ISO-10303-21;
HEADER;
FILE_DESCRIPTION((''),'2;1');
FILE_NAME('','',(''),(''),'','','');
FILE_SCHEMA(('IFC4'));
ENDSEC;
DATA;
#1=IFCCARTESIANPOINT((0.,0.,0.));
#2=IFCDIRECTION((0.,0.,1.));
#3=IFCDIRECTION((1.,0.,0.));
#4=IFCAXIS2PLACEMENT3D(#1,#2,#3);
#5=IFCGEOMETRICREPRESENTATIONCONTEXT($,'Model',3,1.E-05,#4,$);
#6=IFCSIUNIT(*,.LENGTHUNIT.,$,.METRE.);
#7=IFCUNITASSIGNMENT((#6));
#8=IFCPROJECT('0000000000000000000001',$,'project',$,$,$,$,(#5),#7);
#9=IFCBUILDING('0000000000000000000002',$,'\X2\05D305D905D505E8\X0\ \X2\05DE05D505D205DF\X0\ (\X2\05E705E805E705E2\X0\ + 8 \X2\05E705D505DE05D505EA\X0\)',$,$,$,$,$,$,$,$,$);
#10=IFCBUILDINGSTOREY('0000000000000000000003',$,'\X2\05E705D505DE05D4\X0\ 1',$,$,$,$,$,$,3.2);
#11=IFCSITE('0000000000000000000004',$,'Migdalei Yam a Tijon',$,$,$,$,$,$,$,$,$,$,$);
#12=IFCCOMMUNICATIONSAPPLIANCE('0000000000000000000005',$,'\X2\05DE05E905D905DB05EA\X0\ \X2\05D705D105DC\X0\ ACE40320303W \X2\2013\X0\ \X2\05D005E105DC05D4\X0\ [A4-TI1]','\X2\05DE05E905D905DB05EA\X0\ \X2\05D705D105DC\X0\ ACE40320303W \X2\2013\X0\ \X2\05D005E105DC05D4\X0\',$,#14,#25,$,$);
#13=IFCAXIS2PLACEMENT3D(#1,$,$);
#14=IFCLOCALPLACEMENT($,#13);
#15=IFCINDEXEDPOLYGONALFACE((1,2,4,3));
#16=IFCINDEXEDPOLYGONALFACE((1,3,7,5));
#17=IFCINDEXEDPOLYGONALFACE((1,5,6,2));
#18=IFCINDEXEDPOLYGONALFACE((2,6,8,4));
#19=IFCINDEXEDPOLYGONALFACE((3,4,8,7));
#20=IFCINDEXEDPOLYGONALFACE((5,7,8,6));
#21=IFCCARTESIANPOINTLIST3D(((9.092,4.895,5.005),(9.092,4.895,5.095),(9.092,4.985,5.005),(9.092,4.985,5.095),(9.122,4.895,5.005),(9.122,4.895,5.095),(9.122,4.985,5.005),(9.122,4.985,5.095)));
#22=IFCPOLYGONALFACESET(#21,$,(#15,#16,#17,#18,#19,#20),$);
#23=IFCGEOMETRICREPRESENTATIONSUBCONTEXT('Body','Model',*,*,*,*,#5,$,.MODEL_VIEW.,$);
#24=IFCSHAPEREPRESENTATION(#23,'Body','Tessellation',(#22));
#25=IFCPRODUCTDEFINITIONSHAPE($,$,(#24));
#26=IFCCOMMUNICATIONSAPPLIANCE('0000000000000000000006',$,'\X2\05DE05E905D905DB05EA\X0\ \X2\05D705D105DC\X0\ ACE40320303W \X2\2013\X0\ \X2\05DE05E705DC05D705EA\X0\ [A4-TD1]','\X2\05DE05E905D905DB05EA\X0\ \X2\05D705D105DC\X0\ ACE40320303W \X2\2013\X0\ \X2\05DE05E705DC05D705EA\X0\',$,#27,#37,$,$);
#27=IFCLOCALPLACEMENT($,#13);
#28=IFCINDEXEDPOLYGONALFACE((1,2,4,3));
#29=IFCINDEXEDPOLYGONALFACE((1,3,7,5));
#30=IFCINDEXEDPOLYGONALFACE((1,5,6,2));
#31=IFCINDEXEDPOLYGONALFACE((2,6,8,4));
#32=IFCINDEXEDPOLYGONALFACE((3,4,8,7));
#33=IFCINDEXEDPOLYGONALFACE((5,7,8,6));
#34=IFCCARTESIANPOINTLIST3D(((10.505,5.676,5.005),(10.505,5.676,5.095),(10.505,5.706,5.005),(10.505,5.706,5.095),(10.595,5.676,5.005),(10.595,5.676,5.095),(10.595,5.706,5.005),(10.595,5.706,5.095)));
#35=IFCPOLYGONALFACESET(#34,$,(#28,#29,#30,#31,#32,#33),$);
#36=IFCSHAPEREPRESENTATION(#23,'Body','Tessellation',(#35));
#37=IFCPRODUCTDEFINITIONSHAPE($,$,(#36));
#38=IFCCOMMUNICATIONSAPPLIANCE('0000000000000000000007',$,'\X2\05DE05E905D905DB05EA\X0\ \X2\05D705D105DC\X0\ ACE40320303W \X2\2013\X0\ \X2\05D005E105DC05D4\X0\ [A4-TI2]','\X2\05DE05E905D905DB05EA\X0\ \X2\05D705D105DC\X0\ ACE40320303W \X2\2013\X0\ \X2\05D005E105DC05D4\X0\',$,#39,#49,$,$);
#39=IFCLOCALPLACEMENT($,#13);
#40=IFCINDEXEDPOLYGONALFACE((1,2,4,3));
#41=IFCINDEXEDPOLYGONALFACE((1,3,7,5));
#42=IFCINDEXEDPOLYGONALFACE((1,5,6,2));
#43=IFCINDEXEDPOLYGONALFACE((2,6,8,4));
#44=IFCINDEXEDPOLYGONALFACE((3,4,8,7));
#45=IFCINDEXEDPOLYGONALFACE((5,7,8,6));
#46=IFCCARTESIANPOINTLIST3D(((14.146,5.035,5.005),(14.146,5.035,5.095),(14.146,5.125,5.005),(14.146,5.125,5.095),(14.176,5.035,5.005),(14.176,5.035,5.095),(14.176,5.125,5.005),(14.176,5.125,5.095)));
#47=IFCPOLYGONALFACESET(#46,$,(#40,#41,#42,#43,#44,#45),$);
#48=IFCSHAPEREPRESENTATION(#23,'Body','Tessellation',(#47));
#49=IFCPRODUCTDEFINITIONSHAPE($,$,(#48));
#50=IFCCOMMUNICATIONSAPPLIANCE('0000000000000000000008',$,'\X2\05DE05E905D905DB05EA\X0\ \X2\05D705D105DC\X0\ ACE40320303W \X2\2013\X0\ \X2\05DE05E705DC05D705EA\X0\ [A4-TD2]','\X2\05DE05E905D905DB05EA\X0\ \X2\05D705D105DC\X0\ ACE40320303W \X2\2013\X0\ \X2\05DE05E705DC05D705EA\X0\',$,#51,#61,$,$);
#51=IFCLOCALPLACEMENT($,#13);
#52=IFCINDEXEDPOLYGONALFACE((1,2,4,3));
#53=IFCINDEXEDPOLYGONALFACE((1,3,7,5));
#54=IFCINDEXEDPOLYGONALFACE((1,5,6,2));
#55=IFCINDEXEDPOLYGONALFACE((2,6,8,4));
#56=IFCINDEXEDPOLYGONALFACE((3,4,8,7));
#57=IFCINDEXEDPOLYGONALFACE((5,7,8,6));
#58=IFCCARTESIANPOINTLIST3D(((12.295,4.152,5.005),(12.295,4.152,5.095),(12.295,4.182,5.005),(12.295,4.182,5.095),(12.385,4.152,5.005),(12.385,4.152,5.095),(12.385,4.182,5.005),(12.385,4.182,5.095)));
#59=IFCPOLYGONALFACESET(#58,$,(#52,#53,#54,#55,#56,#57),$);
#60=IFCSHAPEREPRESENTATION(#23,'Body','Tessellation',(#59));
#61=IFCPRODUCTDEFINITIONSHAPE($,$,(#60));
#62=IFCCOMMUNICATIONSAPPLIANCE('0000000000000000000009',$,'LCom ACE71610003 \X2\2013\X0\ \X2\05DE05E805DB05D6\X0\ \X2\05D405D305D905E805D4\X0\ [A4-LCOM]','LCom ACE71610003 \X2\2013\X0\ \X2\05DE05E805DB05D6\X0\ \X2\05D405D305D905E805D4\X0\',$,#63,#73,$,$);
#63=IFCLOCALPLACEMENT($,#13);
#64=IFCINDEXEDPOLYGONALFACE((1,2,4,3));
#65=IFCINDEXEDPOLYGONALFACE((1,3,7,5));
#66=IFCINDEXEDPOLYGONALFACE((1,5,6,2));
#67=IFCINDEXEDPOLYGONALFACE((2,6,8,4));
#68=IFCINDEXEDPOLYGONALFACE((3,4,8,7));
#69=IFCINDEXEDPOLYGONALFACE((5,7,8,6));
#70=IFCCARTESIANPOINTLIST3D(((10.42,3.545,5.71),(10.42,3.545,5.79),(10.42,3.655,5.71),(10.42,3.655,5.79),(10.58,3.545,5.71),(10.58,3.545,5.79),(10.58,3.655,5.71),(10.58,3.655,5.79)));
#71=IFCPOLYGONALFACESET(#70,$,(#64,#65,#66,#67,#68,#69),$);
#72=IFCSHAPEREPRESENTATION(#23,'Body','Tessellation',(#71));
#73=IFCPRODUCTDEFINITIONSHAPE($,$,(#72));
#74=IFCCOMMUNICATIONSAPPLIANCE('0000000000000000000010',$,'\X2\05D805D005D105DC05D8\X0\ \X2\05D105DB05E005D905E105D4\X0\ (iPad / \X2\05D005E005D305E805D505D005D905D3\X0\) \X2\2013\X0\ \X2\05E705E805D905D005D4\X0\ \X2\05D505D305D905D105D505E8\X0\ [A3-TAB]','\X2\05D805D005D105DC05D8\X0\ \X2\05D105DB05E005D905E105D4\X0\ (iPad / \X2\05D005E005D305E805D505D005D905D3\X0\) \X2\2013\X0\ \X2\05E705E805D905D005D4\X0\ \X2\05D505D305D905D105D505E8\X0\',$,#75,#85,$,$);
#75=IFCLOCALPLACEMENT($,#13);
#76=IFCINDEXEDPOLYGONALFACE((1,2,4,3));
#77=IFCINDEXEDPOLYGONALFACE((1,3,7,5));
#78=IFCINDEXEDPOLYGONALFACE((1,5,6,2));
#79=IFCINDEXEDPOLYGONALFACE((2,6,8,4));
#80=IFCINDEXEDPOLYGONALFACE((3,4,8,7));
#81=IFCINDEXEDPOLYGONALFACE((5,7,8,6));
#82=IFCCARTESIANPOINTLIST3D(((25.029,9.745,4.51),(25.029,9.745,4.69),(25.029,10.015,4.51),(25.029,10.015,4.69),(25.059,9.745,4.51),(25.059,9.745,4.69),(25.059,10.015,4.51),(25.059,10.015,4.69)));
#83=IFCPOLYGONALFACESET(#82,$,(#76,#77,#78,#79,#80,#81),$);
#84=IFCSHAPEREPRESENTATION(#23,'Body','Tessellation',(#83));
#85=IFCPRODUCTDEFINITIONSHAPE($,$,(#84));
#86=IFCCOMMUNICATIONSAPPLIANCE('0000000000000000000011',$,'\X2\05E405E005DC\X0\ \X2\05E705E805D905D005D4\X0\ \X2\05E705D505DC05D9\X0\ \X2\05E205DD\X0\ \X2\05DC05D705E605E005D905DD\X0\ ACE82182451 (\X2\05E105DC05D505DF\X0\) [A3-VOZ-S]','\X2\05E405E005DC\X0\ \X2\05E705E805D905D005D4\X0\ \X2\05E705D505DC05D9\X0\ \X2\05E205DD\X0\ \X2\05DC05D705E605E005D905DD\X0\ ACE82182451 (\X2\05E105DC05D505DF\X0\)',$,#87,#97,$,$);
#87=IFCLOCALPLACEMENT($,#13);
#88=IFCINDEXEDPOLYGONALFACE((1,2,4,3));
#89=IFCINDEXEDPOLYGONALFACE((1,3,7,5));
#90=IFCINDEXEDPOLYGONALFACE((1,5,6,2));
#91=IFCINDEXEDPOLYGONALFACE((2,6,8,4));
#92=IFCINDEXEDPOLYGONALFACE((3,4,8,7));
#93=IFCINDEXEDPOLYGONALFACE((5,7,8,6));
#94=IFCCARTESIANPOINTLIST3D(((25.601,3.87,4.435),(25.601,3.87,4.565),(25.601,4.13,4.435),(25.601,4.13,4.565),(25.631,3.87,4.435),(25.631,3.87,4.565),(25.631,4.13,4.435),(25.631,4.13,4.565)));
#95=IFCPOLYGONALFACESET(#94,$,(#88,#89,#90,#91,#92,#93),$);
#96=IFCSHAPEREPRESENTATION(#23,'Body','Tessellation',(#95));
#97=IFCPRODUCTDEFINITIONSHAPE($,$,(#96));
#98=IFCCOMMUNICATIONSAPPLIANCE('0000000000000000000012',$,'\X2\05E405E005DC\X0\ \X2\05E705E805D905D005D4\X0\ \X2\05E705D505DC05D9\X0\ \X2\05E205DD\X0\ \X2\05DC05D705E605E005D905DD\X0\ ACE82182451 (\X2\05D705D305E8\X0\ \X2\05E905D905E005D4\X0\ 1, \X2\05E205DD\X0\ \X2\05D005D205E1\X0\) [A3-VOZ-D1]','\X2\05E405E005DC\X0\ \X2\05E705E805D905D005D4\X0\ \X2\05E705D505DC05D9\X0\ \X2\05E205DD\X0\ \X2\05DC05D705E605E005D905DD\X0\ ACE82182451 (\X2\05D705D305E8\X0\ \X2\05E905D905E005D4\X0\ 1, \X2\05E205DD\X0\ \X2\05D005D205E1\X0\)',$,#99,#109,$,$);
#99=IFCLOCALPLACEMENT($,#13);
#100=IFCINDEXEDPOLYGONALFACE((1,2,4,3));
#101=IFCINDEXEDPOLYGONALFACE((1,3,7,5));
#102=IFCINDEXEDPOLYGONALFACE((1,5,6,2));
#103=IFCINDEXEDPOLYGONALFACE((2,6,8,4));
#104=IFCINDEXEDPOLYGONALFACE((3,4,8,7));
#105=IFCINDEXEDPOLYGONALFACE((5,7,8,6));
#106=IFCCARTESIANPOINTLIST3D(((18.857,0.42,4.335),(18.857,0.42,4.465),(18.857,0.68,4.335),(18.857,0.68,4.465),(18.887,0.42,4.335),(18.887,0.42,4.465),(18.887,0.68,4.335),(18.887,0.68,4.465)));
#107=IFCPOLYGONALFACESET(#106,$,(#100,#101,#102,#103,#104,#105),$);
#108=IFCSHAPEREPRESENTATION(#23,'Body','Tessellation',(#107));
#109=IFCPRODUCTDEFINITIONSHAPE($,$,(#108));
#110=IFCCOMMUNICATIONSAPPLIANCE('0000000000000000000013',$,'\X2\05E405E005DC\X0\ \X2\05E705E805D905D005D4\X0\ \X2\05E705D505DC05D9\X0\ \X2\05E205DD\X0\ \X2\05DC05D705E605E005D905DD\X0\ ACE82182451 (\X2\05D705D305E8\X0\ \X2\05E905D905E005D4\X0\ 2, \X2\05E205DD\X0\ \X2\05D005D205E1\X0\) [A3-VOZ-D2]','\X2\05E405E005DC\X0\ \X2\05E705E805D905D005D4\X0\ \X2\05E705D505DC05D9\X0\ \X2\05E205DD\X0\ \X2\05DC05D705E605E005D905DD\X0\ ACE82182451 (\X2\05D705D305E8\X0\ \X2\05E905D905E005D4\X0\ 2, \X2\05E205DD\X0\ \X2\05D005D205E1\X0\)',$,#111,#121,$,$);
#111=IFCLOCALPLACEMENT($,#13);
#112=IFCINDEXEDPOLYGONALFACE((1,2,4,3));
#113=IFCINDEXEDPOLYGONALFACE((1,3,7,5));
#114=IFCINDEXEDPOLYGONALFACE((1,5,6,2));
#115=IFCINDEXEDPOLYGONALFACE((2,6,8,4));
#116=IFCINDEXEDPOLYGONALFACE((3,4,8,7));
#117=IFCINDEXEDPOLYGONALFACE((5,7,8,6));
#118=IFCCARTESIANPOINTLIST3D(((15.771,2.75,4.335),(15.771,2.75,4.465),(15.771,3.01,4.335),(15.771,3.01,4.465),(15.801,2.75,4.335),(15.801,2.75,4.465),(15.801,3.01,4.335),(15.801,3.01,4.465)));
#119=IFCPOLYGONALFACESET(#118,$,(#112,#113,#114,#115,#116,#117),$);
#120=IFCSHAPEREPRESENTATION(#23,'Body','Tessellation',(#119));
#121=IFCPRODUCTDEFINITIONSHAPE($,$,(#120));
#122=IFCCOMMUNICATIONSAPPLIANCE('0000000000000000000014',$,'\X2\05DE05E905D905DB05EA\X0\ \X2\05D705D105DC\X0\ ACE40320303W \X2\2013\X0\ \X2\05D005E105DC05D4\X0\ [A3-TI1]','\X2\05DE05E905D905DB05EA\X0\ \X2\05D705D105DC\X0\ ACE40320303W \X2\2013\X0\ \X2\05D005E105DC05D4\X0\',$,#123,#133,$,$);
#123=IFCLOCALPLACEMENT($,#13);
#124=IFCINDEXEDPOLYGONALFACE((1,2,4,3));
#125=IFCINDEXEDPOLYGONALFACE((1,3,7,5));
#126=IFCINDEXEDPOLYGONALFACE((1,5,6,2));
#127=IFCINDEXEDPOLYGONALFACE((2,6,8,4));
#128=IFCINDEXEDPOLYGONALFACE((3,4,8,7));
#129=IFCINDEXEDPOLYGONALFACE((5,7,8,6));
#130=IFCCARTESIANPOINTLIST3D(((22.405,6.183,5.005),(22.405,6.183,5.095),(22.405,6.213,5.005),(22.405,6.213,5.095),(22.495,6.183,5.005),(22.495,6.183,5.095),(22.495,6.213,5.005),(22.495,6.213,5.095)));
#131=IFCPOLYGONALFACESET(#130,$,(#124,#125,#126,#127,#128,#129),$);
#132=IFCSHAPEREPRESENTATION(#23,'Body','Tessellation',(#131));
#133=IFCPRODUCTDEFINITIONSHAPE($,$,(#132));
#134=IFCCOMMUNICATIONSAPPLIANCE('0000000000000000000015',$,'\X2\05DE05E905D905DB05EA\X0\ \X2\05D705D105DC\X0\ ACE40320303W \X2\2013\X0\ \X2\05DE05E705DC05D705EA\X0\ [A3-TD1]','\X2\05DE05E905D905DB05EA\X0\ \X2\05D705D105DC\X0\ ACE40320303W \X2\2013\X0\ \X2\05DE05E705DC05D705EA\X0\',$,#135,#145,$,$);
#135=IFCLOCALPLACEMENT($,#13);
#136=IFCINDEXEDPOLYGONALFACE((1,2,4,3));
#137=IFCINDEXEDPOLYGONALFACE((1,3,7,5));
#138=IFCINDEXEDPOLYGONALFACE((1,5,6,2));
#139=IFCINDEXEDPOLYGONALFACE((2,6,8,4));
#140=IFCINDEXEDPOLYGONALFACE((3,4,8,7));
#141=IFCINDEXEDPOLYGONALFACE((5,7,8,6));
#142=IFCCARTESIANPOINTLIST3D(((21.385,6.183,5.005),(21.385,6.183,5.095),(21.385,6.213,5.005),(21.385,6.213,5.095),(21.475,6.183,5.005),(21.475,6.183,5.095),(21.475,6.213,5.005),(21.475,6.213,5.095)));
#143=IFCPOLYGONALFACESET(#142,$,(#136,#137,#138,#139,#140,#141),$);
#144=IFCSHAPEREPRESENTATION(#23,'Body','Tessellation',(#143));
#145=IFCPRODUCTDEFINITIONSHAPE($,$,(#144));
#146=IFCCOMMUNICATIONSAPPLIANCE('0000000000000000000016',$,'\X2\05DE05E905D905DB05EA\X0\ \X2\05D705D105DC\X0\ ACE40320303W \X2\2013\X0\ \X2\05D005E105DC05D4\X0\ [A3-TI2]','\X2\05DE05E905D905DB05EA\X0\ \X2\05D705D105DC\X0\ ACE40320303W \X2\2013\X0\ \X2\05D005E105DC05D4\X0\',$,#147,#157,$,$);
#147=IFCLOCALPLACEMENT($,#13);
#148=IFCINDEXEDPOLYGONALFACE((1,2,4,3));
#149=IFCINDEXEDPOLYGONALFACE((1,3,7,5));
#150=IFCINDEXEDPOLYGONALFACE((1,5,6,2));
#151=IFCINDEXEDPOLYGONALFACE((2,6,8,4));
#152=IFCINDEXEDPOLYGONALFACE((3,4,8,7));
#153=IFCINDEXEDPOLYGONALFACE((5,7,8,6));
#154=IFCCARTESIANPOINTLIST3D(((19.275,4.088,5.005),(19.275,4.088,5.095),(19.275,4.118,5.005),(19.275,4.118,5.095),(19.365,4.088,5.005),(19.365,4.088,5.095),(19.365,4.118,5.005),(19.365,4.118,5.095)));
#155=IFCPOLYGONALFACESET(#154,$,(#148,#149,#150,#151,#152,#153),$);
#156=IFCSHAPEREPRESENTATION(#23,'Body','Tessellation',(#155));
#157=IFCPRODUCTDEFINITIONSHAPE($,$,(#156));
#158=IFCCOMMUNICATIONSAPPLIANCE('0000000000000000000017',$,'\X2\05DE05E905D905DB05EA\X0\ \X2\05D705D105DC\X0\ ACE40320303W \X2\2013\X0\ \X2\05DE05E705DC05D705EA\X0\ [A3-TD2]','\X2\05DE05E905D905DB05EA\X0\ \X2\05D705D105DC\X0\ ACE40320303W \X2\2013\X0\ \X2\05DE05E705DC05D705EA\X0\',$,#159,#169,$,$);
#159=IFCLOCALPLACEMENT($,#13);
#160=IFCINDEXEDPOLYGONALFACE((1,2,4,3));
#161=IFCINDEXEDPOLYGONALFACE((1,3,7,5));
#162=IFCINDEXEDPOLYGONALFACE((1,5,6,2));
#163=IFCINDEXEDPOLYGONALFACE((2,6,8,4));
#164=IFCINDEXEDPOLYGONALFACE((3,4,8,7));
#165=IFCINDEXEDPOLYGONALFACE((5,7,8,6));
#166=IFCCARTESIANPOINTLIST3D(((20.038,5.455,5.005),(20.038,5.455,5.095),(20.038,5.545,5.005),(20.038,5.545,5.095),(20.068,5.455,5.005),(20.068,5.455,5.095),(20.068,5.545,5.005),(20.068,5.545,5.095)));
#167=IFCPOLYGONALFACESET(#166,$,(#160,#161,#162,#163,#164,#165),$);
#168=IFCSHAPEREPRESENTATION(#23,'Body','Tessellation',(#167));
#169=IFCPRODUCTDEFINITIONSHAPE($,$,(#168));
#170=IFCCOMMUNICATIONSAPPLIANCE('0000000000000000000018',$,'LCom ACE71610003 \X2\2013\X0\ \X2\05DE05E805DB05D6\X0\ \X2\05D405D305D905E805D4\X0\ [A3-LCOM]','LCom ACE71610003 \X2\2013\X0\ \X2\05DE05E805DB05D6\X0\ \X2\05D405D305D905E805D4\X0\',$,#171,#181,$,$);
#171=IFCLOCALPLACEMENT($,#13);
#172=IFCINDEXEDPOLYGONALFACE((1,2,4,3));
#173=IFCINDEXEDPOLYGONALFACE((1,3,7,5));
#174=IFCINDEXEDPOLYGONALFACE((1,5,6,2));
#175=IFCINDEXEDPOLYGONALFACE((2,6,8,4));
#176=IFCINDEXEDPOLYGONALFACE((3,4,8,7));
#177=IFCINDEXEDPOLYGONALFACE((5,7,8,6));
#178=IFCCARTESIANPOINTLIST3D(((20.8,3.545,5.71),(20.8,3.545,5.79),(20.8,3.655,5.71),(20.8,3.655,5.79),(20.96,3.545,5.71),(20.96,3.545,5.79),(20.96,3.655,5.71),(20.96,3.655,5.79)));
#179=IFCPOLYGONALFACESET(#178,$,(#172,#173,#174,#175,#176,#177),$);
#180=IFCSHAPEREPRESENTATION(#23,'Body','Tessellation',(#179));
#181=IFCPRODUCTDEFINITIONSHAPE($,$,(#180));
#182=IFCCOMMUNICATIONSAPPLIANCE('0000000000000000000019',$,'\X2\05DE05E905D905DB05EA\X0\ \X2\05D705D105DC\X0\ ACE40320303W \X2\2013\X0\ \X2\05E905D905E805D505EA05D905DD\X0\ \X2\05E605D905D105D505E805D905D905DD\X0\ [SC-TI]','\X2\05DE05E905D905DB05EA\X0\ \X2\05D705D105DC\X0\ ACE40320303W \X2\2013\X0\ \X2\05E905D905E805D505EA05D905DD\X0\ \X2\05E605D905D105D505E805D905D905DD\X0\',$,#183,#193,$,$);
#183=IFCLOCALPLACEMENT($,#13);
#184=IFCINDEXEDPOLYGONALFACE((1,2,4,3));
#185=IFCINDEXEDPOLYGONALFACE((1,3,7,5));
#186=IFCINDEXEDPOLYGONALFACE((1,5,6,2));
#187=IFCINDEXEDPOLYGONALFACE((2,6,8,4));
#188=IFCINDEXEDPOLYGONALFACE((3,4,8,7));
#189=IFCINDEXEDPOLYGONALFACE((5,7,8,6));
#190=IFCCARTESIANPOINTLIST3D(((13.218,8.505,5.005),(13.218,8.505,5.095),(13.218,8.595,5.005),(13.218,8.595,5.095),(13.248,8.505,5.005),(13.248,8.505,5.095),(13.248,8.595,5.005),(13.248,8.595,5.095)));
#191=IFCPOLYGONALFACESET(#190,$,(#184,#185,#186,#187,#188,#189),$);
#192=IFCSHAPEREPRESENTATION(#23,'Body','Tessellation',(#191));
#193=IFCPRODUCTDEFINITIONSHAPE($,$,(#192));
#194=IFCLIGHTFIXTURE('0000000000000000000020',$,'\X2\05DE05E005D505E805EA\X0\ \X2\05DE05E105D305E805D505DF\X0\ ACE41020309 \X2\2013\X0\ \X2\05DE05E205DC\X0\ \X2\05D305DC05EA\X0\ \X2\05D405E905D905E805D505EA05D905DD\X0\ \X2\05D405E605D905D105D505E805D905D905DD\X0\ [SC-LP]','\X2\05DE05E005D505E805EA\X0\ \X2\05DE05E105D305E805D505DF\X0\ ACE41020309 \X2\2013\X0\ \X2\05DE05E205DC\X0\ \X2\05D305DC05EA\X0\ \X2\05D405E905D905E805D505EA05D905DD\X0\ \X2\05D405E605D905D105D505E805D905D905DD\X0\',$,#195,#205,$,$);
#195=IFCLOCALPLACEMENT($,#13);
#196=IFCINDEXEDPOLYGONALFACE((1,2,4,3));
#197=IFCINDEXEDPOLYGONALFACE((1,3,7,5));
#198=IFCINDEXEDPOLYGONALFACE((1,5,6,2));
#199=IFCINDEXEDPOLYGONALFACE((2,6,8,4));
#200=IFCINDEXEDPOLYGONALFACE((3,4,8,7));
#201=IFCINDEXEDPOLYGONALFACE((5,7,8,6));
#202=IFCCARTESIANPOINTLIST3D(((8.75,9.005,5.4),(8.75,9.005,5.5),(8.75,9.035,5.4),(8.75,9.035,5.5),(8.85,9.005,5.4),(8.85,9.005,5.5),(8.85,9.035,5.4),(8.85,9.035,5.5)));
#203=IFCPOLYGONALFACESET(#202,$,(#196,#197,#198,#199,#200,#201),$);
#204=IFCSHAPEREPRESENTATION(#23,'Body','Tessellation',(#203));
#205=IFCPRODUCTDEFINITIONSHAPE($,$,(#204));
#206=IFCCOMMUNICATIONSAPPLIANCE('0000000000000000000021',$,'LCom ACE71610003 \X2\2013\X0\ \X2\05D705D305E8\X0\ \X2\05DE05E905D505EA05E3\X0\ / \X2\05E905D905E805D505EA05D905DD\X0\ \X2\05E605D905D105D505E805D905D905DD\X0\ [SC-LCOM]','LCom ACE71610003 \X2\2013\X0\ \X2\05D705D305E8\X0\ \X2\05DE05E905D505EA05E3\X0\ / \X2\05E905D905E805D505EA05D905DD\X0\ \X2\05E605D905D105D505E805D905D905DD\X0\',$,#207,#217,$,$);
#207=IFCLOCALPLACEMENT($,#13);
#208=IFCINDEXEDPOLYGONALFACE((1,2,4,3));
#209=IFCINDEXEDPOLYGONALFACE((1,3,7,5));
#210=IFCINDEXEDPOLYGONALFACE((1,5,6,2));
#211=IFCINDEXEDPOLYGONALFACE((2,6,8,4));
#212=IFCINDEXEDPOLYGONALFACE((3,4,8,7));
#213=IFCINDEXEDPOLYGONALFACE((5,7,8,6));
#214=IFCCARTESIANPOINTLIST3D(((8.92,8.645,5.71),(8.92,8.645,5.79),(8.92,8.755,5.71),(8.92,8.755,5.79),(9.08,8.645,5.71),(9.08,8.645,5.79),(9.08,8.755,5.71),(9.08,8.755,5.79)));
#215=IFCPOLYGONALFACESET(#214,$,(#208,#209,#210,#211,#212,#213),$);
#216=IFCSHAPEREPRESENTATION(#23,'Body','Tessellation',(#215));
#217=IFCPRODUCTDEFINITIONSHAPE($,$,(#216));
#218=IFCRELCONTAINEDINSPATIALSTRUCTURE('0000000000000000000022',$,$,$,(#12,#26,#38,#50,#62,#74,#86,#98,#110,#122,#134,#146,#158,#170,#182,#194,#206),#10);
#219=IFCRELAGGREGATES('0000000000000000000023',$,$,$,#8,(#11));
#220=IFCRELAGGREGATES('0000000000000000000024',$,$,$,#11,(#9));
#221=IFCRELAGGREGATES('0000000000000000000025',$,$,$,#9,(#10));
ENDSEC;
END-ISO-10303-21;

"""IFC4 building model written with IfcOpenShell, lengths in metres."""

from ifc_helpers import new_model, si_unit, frame, origin_with_axes, context, subcontext, project, spatial, line, indexed_curve, outline, extrude, element, save


model = new_model("IFC4")

# Units and contexts
model_context = context("Model", 3, precision=1e-05, world=origin_with_axes())
body_context = subcontext(model_context, "Body", "Model", "MODEL_VIEW")
ifc_project = project(units=[si_unit("LENGTHUNIT", "METRE")], contexts=[model_context])

# Site, building, storey
site = spatial("IfcSite", under=ifc_project, Name="Migdalei Yam a Tijon")
building = spatial("IfcBuilding", under=site, Name="דיור מוגן (קרקע + 8 קומות)")
storey = spatial("IfcBuildingStorey", under=building, Name="קומה 1", Elevation=3.2)

# Communications appliances
element("IfcCommunicationsAppliance", 1, inside=storey, Name="משיכת חבל ACE40320303W – אסלה [A4-TI1]", Description="משיכת חבל ACE40320303W – אסלה", context=body_context, shape_type="SweptSolid", body=[
    extrude(outline(indexed_curve([(0.0, 0.0), (0.03, 0.0), (0.03, 0.09), (0.0, 0.09)], segments=[line(1, 2, 3, 4, 1)])), frame((9.092, 4.895, 5.005), z_axis=(0.0, 0.0, 1.0), x_axis=(1.0, 0.0, 0.0)), (0.0, 0.0, 1.0), 0.09),
])
element("IfcCommunicationsAppliance", 2, inside=storey, Name="משיכת חבל ACE40320303W – מקלחת [A4-TD1]", Description="משיכת חבל ACE40320303W – מקלחת", context=body_context, shape_type="SweptSolid", body=[
    extrude(outline(indexed_curve([(0.0, 0.0), (0.09, 0.0), (0.09, 0.03), (0.0, 0.03)], segments=[line(1, 2, 3, 4, 1)])), frame((10.505, 5.676, 5.005), z_axis=(0.0, 0.0, 1.0), x_axis=(1.0, 0.0, 0.0)), (0.0, 0.0, 1.0), 0.09),
])
element("IfcCommunicationsAppliance", 3, inside=storey, Name="משיכת חבל ACE40320303W – אסלה [A4-TI2]", Description="משיכת חבל ACE40320303W – אסלה", context=body_context, shape_type="SweptSolid", body=[
    extrude(outline(indexed_curve([(0.0, 0.0), (0.03, 0.0), (0.03, 0.09), (0.0, 0.09)], segments=[line(1, 2, 3, 4, 1)])), frame((14.146, 5.035, 5.005), z_axis=(0.0, 0.0, 1.0), x_axis=(1.0, 0.0, 0.0)), (0.0, 0.0, 1.0), 0.09),
])
element("IfcCommunicationsAppliance", 4, inside=storey, Name="משיכת חבל ACE40320303W – מקלחת [A4-TD2]", Description="משיכת חבל ACE40320303W – מקלחת", context=body_context, shape_type="SweptSolid", body=[
    extrude(outline(indexed_curve([(0.0, 0.0), (0.09, 0.0), (0.09, 0.03), (0.0, 0.03)], segments=[line(1, 2, 3, 4, 1)])), frame((12.295, 4.152, 5.005), z_axis=(0.0, 0.0, 1.0), x_axis=(1.0, 0.0, 0.0)), (0.0, 0.0, 1.0), 0.09),
])
element("IfcCommunicationsAppliance", 5, inside=storey, Name="LCom ACE71610003 – מרכז הדירה [A4-LCOM]", Description="LCom ACE71610003 – מרכז הדירה", context=body_context, shape_type="SweptSolid", body=[
    extrude(outline(indexed_curve([(0.0, 0.0), (0.16, 0.0), (0.16, 0.11), (0.0, 0.11)], segments=[line(1, 2, 3, 4, 1)])), frame((10.42, 3.545, 5.71), z_axis=(0.0, 0.0, 1.0), x_axis=(1.0, 0.0, 0.0)), (0.0, 0.0, 1.0), 0.08),
])
element("IfcCommunicationsAppliance", 6, inside=storey, Name="טאבלט בכניסה (iPad / אנדרואיד) – קריאה ודיבור [A3-TAB]", Description="טאבלט בכניסה (iPad / אנדרואיד) – קריאה ודיבור", context=body_context, shape_type="SweptSolid", body=[
    extrude(outline(indexed_curve([(0.0, 0.0), (0.03, 0.0), (0.03, 0.27), (0.0, 0.27)], segments=[line(1, 2, 3, 4, 1)])), frame((25.029, 9.745, 4.51), z_axis=(0.0, 0.0, 1.0), x_axis=(1.0, 0.0, 0.0)), (0.0, 0.0, 1.0), 0.18),
])
element("IfcCommunicationsAppliance", 7, inside=storey, Name="פנל קריאה קולי עם לחצנים ACE82182451 (סלון) [A3-VOZ-S]", Description="פנל קריאה קולי עם לחצנים ACE82182451 (סלון)", context=body_context, shape_type="SweptSolid", body=[
    extrude(outline(indexed_curve([(0.0, 0.0), (0.03, 0.0), (0.03, 0.26), (0.0, 0.26)], segments=[line(1, 2, 3, 4, 1)])), frame((25.601, 3.87, 4.435), z_axis=(0.0, 0.0, 1.0), x_axis=(1.0, 0.0, 0.0)), (0.0, 0.0, 1.0), 0.13),
])
element("IfcCommunicationsAppliance", 8, inside=storey, Name="פנל קריאה קולי עם לחצנים ACE82182451 (חדר שינה 1, עם אגס) [A3-VOZ-D1]", Description="פנל קריאה קולי עם לחצנים ACE82182451 (חדר שינה 1, עם אגס)", context=body_context, shape_type="SweptSolid", body=[
    extrude(outline(indexed_curve([(0.0, 0.0), (0.03, 0.0), (0.03, 0.26), (0.0, 0.26)], segments=[line(1, 2, 3, 4, 1)])), frame((18.857, 0.42, 4.335), z_axis=(0.0, 0.0, 1.0), x_axis=(1.0, 0.0, 0.0)), (0.0, 0.0, 1.0), 0.13),
])
element("IfcCommunicationsAppliance", 9, inside=storey, Name="פנל קריאה קולי עם לחצנים ACE82182451 (חדר שינה 2, עם אגס) [A3-VOZ-D2]", Description="פנל קריאה קולי עם לחצנים ACE82182451 (חדר שינה 2, עם אגס)", context=body_context, shape_type="SweptSolid", body=[
    extrude(outline(indexed_curve([(0.0, 0.0), (0.03, 0.0), (0.03, 0.26), (0.0, 0.26)], segments=[line(1, 2, 3, 4, 1)])), frame((15.771, 2.75, 4.335), z_axis=(0.0, 0.0, 1.0), x_axis=(1.0, 0.0, 0.0)), (0.0, 0.0, 1.0), 0.13),
])
element("IfcCommunicationsAppliance", 10, inside=storey, Name="משיכת חבל ACE40320303W – אסלה [A3-TI1]", Description="משיכת חבל ACE40320303W – אסלה", context=body_context, shape_type="SweptSolid", body=[
    extrude(outline(indexed_curve([(0.0, 0.0), (0.09, 0.0), (0.09, 0.03), (0.0, 0.03)], segments=[line(1, 2, 3, 4, 1)])), frame((22.405, 6.183, 5.005), z_axis=(0.0, 0.0, 1.0), x_axis=(1.0, 0.0, 0.0)), (0.0, 0.0, 1.0), 0.09),
])
element("IfcCommunicationsAppliance", 11, inside=storey, Name="משיכת חבל ACE40320303W – מקלחת [A3-TD1]", Description="משיכת חבל ACE40320303W – מקלחת", context=body_context, shape_type="SweptSolid", body=[
    extrude(outline(indexed_curve([(0.0, 0.0), (0.09, 0.0), (0.09, 0.03), (0.0, 0.03)], segments=[line(1, 2, 3, 4, 1)])), frame((21.385, 6.183, 5.005), z_axis=(0.0, 0.0, 1.0), x_axis=(1.0, 0.0, 0.0)), (0.0, 0.0, 1.0), 0.09),
])
element("IfcCommunicationsAppliance", 12, inside=storey, Name="משיכת חבל ACE40320303W – אסלה [A3-TI2]", Description="משיכת חבל ACE40320303W – אסלה", context=body_context, shape_type="SweptSolid", body=[
    extrude(outline(indexed_curve([(0.0, 0.0), (0.09, 0.0), (0.09, 0.03), (0.0, 0.03)], segments=[line(1, 2, 3, 4, 1)])), frame((19.275, 4.088, 5.005), z_axis=(0.0, 0.0, 1.0), x_axis=(1.0, 0.0, 0.0)), (0.0, 0.0, 1.0), 0.09),
])
element("IfcCommunicationsAppliance", 13, inside=storey, Name="משיכת חבל ACE40320303W – מקלחת [A3-TD2]", Description="משיכת חבל ACE40320303W – מקלחת", context=body_context, shape_type="SweptSolid", body=[
    extrude(outline(indexed_curve([(0.0, 0.0), (0.03, 0.0), (0.03, 0.09), (0.0, 0.09)], segments=[line(1, 2, 3, 4, 1)])), frame((20.038, 5.455, 5.005), z_axis=(0.0, 0.0, 1.0), x_axis=(1.0, 0.0, 0.0)), (0.0, 0.0, 1.0), 0.09),
])
element("IfcCommunicationsAppliance", 14, inside=storey, Name="LCom ACE71610003 – מרכז הדירה [A3-LCOM]", Description="LCom ACE71610003 – מרכז הדירה", context=body_context, shape_type="SweptSolid", body=[
    extrude(outline(indexed_curve([(0.0, 0.0), (0.16, 0.0), (0.16, 0.11), (0.0, 0.11)], segments=[line(1, 2, 3, 4, 1)])), frame((20.8, 3.545, 5.71), z_axis=(0.0, 0.0, 1.0), x_axis=(1.0, 0.0, 0.0)), (0.0, 0.0, 1.0), 0.08),
])
element("IfcCommunicationsAppliance", 15, inside=storey, Name="משיכת חבל ACE40320303W – שירותים ציבוריים [SC-TI]", Description="משיכת חבל ACE40320303W – שירותים ציבוריים", context=body_context, shape_type="SweptSolid", body=[
    extrude(outline(indexed_curve([(0.0, 0.0), (0.03, 0.0), (0.03, 0.09), (0.0, 0.09)], segments=[line(1, 2, 3, 4, 1)])), frame((13.218, 8.505, 5.005), z_axis=(0.0, 0.0, 1.0), x_axis=(1.0, 0.0, 0.0)), (0.0, 0.0, 1.0), 0.09),
])

# Light fixture
element("IfcLightFixture", 16, inside=storey, Name="מנורת מסדרון ACE41020309 – מעל דלת השירותים הציבוריים [SC-LP]", Description="מנורת מסדרון ACE41020309 – מעל דלת השירותים הציבוריים", context=body_context, shape_type="SweptSolid", body=[
    extrude(outline(indexed_curve([(0.0, 0.0), (0.1, 0.0), (0.1, 0.03), (0.0, 0.03)], segments=[line(1, 2, 3, 4, 1)])), frame((8.75, 9.005, 5.4), z_axis=(0.0, 0.0, 1.0), x_axis=(1.0, 0.0, 0.0)), (0.0, 0.0, 1.0), 0.1),
])

# Communications appliance
element("IfcCommunicationsAppliance", 17, inside=storey, Name="LCom ACE71610003 – חדר משותף / שירותים ציבוריים [SC-LCOM]", Description="LCom ACE71610003 – חדר משותף / שירותים ציבוריים", context=body_context, shape_type="SweptSolid", body=[
    extrude(outline(indexed_curve([(0.0, 0.0), (0.16, 0.0), (0.16, 0.11), (0.0, 0.11)], segments=[line(1, 2, 3, 4, 1)])), frame((8.92, 8.645, 5.71), z_axis=(0.0, 0.0, 1.0), x_axis=(1.0, 0.0, 0.0)), (0.0, 0.0, 1.0), 0.08),
])

save(model, "model.ifc")
